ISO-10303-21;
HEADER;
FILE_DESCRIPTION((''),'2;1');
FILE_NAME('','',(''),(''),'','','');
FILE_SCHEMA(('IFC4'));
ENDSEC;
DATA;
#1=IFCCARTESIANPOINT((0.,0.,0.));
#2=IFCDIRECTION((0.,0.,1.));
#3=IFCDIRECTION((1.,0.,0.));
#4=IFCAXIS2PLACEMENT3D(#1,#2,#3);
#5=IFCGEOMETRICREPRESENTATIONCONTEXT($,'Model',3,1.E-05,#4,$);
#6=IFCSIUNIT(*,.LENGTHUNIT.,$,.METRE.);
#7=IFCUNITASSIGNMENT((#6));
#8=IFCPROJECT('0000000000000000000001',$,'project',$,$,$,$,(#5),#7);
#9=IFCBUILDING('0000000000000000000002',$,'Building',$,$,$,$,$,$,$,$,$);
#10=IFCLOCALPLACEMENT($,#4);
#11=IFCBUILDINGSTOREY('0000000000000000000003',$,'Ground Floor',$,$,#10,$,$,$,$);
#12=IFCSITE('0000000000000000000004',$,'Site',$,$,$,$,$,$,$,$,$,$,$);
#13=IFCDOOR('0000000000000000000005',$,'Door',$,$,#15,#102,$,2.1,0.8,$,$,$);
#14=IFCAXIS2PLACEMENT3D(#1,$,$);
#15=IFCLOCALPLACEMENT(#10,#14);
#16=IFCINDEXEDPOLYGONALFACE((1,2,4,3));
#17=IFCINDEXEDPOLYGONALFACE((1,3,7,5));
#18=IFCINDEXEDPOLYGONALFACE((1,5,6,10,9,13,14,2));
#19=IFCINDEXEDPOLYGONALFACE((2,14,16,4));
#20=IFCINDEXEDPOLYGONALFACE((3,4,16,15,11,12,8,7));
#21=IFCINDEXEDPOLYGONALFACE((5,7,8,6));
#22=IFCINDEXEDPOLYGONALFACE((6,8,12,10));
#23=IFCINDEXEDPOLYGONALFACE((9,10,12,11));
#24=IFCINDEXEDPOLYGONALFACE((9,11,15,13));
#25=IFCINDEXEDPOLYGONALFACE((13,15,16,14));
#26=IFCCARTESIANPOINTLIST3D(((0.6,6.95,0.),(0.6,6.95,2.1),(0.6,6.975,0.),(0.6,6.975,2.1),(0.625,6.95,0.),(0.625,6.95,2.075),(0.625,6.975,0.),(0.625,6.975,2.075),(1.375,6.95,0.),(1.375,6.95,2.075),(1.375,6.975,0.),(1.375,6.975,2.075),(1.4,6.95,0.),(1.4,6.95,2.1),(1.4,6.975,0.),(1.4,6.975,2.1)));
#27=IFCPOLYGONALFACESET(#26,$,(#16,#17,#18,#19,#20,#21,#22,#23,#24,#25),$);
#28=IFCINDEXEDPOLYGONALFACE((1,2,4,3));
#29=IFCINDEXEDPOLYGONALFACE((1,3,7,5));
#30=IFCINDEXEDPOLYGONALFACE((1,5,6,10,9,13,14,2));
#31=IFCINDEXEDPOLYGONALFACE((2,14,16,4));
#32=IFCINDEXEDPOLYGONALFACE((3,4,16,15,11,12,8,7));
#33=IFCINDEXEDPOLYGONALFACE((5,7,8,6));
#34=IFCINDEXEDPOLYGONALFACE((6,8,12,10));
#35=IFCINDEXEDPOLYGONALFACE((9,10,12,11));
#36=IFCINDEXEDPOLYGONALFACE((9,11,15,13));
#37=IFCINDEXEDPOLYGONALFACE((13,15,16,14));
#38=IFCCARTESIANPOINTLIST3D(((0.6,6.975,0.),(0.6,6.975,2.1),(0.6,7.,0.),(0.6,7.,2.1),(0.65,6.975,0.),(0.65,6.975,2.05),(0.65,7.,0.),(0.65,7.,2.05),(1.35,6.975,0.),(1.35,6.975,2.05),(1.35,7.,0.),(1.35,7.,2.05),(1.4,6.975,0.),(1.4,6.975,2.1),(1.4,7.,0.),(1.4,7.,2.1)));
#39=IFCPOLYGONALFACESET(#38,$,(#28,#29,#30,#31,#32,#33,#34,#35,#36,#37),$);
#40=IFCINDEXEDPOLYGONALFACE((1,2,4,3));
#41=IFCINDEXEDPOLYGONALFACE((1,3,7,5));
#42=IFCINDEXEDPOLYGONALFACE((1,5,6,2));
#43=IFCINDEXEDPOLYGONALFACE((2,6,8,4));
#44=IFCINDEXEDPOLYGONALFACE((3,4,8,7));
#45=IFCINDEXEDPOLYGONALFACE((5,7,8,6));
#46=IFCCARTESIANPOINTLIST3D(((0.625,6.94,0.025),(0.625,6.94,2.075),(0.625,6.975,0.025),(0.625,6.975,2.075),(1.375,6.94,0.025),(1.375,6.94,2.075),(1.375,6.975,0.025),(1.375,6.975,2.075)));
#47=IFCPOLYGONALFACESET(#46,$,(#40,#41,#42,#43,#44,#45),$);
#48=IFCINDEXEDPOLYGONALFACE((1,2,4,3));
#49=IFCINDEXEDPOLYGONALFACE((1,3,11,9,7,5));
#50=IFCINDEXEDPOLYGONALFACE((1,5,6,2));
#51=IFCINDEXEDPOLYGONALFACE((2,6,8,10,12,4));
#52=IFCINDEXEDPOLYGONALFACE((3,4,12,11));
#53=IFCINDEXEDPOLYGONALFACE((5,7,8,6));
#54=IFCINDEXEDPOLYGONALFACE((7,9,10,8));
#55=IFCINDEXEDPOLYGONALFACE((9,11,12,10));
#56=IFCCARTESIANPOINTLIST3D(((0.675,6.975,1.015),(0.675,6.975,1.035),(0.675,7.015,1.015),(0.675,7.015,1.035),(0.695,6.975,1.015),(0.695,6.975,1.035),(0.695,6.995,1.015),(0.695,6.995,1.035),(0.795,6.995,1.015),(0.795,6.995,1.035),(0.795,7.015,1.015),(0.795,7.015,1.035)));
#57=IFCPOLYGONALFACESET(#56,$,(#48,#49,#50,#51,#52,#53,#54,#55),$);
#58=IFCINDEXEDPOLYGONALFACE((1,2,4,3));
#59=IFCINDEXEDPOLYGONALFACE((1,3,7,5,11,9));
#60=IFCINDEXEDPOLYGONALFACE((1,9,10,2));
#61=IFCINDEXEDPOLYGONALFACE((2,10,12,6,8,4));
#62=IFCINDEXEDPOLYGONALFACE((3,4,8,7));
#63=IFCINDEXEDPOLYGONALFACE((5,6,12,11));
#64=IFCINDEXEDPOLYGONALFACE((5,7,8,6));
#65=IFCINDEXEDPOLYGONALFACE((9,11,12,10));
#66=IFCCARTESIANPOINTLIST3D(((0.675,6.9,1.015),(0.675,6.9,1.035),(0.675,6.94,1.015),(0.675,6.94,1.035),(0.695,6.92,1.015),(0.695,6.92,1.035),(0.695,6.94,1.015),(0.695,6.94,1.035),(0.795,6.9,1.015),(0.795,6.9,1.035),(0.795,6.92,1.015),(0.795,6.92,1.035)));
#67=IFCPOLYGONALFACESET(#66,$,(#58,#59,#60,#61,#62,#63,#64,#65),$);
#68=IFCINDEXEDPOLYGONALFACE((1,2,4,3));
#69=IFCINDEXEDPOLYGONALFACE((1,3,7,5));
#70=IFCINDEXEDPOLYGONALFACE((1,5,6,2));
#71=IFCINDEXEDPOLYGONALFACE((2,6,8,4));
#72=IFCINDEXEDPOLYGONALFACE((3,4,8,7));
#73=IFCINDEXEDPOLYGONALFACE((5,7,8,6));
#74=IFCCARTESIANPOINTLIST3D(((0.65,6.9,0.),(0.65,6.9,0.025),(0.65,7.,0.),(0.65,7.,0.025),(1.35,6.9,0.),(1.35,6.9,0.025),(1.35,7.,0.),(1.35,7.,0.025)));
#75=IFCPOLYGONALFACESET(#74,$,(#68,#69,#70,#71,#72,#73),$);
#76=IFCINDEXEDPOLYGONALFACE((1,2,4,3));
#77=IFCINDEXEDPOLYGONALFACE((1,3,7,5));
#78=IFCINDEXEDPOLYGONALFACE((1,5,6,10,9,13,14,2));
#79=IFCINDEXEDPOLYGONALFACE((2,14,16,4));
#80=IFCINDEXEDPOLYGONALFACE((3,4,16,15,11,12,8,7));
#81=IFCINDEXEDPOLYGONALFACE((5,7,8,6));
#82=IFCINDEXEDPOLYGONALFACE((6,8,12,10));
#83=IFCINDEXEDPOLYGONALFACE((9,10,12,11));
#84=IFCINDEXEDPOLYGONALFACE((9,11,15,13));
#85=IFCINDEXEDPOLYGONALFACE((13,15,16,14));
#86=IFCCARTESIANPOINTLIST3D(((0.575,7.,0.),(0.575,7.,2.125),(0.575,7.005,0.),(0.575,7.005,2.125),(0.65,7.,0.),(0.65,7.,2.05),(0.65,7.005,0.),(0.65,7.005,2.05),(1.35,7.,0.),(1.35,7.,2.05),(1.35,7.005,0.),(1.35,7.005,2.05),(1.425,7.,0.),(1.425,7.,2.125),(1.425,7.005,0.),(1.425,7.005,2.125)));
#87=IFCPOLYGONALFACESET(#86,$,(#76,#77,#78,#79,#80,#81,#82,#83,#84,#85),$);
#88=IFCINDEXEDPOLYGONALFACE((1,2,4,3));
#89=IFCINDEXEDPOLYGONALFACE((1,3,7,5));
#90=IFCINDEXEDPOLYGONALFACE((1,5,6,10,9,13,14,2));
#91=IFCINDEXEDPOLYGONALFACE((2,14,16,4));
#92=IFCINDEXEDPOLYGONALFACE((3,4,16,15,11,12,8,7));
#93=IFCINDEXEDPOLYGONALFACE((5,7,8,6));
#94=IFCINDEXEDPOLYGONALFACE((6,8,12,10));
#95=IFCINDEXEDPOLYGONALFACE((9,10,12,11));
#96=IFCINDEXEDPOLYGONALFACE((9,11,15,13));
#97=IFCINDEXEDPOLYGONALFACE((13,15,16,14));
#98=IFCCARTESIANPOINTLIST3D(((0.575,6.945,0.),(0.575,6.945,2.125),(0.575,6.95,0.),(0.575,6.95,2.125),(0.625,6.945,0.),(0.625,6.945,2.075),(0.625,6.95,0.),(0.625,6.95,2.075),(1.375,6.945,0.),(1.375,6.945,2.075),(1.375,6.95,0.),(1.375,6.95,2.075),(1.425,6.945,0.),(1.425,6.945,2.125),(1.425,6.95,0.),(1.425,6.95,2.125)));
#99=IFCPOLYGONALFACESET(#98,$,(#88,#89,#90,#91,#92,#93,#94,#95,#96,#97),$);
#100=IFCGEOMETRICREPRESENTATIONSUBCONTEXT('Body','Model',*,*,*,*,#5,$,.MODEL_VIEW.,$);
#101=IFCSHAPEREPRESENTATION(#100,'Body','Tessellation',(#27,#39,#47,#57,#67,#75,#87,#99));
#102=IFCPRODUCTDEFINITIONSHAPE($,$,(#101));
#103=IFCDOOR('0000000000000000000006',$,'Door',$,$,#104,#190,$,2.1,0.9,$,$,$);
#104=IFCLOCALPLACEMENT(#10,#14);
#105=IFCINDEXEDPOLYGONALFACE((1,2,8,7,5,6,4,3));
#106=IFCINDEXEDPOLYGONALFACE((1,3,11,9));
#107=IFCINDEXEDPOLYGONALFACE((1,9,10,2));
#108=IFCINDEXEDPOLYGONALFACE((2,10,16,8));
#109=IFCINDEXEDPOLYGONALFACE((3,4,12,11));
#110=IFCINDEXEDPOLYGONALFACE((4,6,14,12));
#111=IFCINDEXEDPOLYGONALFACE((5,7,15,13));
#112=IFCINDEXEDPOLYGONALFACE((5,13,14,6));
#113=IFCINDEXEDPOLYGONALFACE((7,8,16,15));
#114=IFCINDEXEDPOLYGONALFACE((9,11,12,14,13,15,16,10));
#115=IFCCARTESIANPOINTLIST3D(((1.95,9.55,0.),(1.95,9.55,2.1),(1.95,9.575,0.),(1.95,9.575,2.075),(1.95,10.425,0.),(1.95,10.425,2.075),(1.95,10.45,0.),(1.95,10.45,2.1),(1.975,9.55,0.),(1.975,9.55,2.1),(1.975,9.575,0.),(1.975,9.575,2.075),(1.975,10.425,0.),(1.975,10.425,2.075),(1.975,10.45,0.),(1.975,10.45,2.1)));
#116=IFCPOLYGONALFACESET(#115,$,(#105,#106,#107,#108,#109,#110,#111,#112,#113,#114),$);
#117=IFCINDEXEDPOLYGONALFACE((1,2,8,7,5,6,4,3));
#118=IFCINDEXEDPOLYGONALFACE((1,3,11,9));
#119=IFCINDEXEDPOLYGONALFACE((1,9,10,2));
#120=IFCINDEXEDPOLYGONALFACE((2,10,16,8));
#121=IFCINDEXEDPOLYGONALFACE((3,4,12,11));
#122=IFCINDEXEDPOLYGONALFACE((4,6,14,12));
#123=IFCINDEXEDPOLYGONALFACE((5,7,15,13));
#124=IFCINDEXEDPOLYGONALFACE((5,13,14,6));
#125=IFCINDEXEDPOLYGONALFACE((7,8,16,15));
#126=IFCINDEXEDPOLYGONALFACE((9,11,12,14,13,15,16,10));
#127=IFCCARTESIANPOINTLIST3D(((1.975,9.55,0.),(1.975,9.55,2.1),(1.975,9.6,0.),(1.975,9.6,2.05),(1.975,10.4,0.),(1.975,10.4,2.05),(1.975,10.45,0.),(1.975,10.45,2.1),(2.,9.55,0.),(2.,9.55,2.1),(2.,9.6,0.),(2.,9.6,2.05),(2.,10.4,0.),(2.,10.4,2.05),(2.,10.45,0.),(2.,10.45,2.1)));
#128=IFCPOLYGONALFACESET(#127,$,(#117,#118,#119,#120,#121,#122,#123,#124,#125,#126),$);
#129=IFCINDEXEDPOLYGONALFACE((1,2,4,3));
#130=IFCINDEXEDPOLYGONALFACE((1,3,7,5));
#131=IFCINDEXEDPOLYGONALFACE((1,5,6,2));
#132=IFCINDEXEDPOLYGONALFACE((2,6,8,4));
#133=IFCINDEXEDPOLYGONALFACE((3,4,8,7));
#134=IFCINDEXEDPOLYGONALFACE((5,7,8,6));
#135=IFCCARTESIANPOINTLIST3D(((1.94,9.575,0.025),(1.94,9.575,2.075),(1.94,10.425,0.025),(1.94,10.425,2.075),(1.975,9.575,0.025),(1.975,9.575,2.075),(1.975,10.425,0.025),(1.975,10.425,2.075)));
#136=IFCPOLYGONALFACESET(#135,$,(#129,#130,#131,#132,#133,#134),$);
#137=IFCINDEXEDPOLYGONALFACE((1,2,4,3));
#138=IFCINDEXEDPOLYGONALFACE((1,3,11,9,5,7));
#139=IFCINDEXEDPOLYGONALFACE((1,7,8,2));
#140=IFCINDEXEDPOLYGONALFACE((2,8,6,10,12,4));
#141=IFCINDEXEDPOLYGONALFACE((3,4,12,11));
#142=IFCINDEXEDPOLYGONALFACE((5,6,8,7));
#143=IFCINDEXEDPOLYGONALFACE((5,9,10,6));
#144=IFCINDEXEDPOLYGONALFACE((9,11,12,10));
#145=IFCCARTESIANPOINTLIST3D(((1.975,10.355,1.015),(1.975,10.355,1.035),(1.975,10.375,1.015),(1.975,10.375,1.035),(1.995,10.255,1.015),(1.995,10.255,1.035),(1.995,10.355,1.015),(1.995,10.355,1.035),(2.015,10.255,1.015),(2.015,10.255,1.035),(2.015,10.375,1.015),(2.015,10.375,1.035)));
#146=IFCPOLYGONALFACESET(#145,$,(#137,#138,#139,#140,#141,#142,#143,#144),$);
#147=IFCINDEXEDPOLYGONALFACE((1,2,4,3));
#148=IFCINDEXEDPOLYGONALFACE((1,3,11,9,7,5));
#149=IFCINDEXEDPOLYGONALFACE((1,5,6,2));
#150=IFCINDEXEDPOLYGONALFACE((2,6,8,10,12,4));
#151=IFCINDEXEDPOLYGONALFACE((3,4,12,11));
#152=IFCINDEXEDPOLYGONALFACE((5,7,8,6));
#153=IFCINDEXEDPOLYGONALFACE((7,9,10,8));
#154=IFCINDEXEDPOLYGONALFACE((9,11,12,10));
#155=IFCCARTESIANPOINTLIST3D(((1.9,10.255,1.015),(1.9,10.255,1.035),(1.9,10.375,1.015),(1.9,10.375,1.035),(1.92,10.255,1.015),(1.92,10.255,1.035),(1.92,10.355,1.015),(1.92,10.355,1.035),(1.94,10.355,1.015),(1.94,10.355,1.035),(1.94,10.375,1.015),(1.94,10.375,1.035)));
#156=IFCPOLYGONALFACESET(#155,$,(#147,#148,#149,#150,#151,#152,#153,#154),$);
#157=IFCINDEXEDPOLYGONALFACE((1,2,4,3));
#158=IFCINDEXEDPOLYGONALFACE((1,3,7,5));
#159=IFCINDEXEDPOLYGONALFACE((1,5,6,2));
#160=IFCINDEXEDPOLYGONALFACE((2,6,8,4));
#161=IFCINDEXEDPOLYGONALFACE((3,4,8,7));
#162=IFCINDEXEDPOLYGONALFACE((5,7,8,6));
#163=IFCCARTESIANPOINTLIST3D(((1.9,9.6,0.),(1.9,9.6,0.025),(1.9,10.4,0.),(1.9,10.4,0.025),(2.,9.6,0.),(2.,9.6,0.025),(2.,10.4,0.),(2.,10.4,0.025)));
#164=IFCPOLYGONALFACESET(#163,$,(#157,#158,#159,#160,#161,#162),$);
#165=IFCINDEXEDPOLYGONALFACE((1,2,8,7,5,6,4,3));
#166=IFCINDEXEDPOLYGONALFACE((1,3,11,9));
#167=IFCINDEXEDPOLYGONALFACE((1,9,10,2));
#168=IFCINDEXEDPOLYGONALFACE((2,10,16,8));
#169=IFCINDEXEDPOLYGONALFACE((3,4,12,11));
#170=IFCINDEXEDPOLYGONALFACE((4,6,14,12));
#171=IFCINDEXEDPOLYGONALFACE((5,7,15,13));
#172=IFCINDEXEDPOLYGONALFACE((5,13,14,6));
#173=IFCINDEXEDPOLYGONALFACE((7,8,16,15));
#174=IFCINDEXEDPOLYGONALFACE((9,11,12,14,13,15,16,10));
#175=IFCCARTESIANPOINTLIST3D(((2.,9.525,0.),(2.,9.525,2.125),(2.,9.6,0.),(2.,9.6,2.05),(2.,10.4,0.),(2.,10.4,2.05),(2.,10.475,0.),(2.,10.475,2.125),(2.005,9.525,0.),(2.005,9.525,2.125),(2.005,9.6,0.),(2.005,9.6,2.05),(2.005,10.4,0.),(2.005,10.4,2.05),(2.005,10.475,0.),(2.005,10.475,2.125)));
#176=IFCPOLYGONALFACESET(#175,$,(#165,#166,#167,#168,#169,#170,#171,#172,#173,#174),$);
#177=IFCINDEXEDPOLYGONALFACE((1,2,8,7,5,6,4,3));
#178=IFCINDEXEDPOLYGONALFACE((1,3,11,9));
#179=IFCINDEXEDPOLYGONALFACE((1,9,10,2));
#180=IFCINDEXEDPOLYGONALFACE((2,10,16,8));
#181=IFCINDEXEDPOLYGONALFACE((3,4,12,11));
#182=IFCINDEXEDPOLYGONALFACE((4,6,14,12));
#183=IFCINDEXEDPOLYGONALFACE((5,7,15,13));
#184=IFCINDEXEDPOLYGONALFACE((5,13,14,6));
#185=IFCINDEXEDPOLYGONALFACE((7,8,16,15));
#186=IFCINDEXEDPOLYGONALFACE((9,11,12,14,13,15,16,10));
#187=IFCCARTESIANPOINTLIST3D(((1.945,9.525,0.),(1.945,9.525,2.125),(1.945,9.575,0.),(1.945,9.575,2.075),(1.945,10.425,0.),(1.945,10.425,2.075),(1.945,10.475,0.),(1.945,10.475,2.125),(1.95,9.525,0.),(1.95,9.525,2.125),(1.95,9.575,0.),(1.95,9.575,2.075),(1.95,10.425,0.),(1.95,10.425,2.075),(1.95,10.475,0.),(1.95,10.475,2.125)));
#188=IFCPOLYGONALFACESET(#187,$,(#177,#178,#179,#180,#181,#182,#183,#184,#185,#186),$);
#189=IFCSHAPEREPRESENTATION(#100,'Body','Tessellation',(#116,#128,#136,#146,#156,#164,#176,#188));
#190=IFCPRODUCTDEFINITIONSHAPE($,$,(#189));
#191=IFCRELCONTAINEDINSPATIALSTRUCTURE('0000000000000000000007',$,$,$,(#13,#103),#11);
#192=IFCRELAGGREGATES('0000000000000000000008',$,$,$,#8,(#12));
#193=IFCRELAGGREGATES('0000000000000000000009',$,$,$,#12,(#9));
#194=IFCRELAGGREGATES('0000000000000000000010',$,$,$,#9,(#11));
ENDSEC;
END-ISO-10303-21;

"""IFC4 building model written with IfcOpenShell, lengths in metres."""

from ifc_helpers import new_model, si_unit, frame, origin_with_axes, place, context, subcontext, project, spatial, line, indexed_curve, outline, extrude, element, save


model = new_model("IFC4")

# Units and contexts
model_context = context("Model", 3, precision=1e-05, world=origin_with_axes())
body_context = subcontext(model_context, "Body", "Model", "MODEL_VIEW")
ifc_project = project(units=[si_unit("LENGTHUNIT", "METRE")], contexts=[model_context])

# Site, building, storey
site = spatial("IfcSite", under=ifc_project, Name="Site")
building = spatial("IfcBuilding", under=site, Name="Building")
storey_placement = place(None, origin_with_axes())
storey = spatial("IfcBuildingStorey", under=building, at=storey_placement, Name="Ground Floor")

# Doors
door_1_placement = place(storey_placement, frame((1.4, 7.0, 0.0), z_axis=(0.0, 0.0, 1.0), x_axis=(-1.0, 0.0, 0.0)))
element("IfcDoor", 1, at=door_1_placement, inside=storey, Name="Door", OverallHeight=2.1, OverallWidth=0.8, context=body_context, shape_type="SweptSolid", body=[
    extrude(outline(indexed_curve([(0.0, 0.0), (0.0, 2.1), (0.8, 2.1), (0.8, 0.0), (0.775, 0.0), (0.775, 2.075), (0.025, 2.075), (0.025, 0.0)], segments=[line(1, 2, 3, 4, 5, 6, 7, 8, 1)])), frame((0.0, 0.025, 0.0), z_axis=(0.0, -1.0, 0.0), x_axis=(1.0, 0.0, 0.0)), (0.0, 0.0, -1.0), 0.025),
    extrude(outline(indexed_curve([(0.0, 0.0), (0.0, 2.1), (0.8, 2.1), (0.8, 0.0), (0.75, 0.0), (0.75, 2.05), (0.05, 2.05), (0.05, 0.0)], segments=[line(1, 2, 3, 4, 5, 6, 7, 8, 1)])), frame((0.0, 0.0, 0.0), z_axis=(0.0, -1.0, 0.0), x_axis=(1.0, 0.0, 0.0)), (0.0, 0.0, -1.0), 0.025),
    extrude(outline(indexed_curve([(0.0, 0.0), (0.75, 0.0), (0.75, 0.035), (0.0, 0.035)], segments=[line(1, 2, 3, 4, 1)])), frame((0.025, 0.025, 0.025), z_axis=(0.0, 0.0, 1.0), x_axis=(1.0, 0.0, 0.0)), (0.0, 0.0, 1.0), 2.05),
    extrude(outline(indexed_curve([(0.0, 0.0), (0.0, -0.04), (-0.12, -0.04), (-0.12, -0.02), (-0.02, -0.02), (-0.02, 0.0)], segments=[line(1, 2, 3, 4, 5, 6, 1)])), frame((0.725, 0.025, 1.015), z_axis=(0.0, 0.0, 1.0), x_axis=(1.0, 0.0, 0.0)), (0.0, 0.0, 1.0), 0.02),
    extrude(outline(indexed_curve([(0.0, 0.0), (0.0, 0.04), (-0.12, 0.04), (-0.12, 0.02), (-0.02, 0.02), (-0.02, 0.0)], segments=[line(1, 2, 3, 4, 5, 6, 1)])), frame((0.725, 0.06, 1.015), z_axis=(0.0, 0.0, 1.0), x_axis=(1.0, 0.0, 0.0)), (0.0, 0.0, 1.0), 0.02),
    extrude(outline(indexed_curve([(0.0, 0.0), (0.7, 0.0), (0.7, 0.1), (0.0, 0.1)], segments=[line(1, 2, 3, 4, 1)])), frame((0.05, 0.0, 0.0), z_axis=(0.0, 0.0, 1.0), x_axis=(1.0, 0.0, 0.0)), (0.0, 0.0, 1.0), 0.025),
    extrude(outline(indexed_curve([(0.0, 0.0), (0.0, 2.125), (0.85, 2.125), (0.85, 0.0), (0.775, 0.0), (0.775, 2.05), (0.075, 2.05), (0.075, 0.0)], segments=[line(1, 2, 3, 4, 5, 6, 7, 8, 1)])), frame((-0.025, -0.005, 0.0), z_axis=(0.0, -1.0, 0.0), x_axis=(1.0, 0.0, 0.0)), (0.0, 0.0, -1.0), 0.005),
    extrude(outline(indexed_curve([(0.0, 0.0), (0.0, 2.125), (0.85, 2.125), (0.85, 0.0), (0.8, 0.0), (0.8, 2.075), (0.05, 2.075), (0.05, 0.0)], segments=[line(1, 2, 3, 4, 5, 6, 7, 8, 1)])), frame((-0.025, 0.05, 0.0), z_axis=(0.0, -1.0, 0.0), x_axis=(1.0, 0.0, 0.0)), (0.0, 0.0, -1.0), 0.005),
])
door_2_placement = place(storey_placement, frame((2.0, 9.55, 0.0), z_axis=(0.0, 0.0, 1.0), x_axis=(0.0, 1.0, 0.0)))
element("IfcDoor", 2, at=door_2_placement, inside=storey, Name="Door", OverallHeight=2.1, OverallWidth=0.9, context=body_context, shape_type="SweptSolid", body=[
    extrude(outline(indexed_curve([(0.0, 0.0), (0.0, 2.1), (0.9, 2.1), (0.9, 0.0), (0.875, 0.0), (0.875, 2.075), (0.025, 2.075), (0.025, 0.0)], segments=[line(1, 2, 3, 4, 5, 6, 7, 8, 1)])), frame((0.0, 0.025, 0.0), z_axis=(0.0, -1.0, 0.0), x_axis=(1.0, 0.0, 0.0)), (0.0, 0.0, -1.0), 0.025),
    extrude(outline(indexed_curve([(0.0, 0.0), (0.0, 2.1), (0.9, 2.1), (0.9, 0.0), (0.85, 0.0), (0.85, 2.05), (0.05, 2.05), (0.05, 0.0)], segments=[line(1, 2, 3, 4, 5, 6, 7, 8, 1)])), frame((0.0, 0.0, 0.0), z_axis=(0.0, -1.0, 0.0), x_axis=(1.0, 0.0, 0.0)), (0.0, 0.0, -1.0), 0.025),
    extrude(outline(indexed_curve([(0.0, 0.0), (0.85, 0.0), (0.85, 0.035), (0.0, 0.035)], segments=[line(1, 2, 3, 4, 1)])), frame((0.025, 0.025, 0.025), z_axis=(0.0, 0.0, 1.0), x_axis=(1.0, 0.0, 0.0)), (0.0, 0.0, 1.0), 2.05),
    extrude(outline(indexed_curve([(0.0, 0.0), (0.0, -0.04), (-0.12, -0.04), (-0.12, -0.02), (-0.02, -0.02), (-0.02, 0.0)], segments=[line(1, 2, 3, 4, 5, 6, 1)])), frame((0.825, 0.025, 1.015), z_axis=(0.0, 0.0, 1.0), x_axis=(1.0, 0.0, 0.0)), (0.0, 0.0, 1.0), 0.02),
    extrude(outline(indexed_curve([(0.0, 0.0), (0.0, 0.04), (-0.12, 0.04), (-0.12, 0.02), (-0.02, 0.02), (-0.02, 0.0)], segments=[line(1, 2, 3, 4, 5, 6, 1)])), frame((0.825, 0.06, 1.015), z_axis=(0.0, 0.0, 1.0), x_axis=(1.0, 0.0, 0.0)), (0.0, 0.0, 1.0), 0.02),
    extrude(outline(indexed_curve([(0.0, 0.0), (0.8, 0.0), (0.8, 0.1), (0.0, 0.1)], segments=[line(1, 2, 3, 4, 1)])), frame((0.05, 0.0, 0.0), z_axis=(0.0, 0.0, 1.0), x_axis=(1.0, 0.0, 0.0)), (0.0, 0.0, 1.0), 0.025),
    extrude(outline(indexed_curve([(0.0, 0.0), (0.0, 2.125), (0.95, 2.125), (0.95, 0.0), (0.875, 0.0), (0.875, 2.05), (0.075, 2.05), (0.075, 0.0)], segments=[line(1, 2, 3, 4, 5, 6, 7, 8, 1)])), frame((-0.025, -0.005, 0.0), z_axis=(0.0, -1.0, 0.0), x_axis=(1.0, 0.0, 0.0)), (0.0, 0.0, -1.0), 0.005),
    extrude(outline(indexed_curve([(0.0, 0.0), (0.0, 2.125), (0.95, 2.125), (0.95, 0.0), (0.9, 0.0), (0.9, 2.075), (0.05, 2.075), (0.05, 0.0)], segments=[line(1, 2, 3, 4, 5, 6, 7, 8, 1)])), frame((-0.025, 0.05, 0.0), z_axis=(0.0, -1.0, 0.0), x_axis=(1.0, 0.0, 0.0)), (0.0, 0.0, -1.0), 0.005),
])

save(model, "model.ifc")
